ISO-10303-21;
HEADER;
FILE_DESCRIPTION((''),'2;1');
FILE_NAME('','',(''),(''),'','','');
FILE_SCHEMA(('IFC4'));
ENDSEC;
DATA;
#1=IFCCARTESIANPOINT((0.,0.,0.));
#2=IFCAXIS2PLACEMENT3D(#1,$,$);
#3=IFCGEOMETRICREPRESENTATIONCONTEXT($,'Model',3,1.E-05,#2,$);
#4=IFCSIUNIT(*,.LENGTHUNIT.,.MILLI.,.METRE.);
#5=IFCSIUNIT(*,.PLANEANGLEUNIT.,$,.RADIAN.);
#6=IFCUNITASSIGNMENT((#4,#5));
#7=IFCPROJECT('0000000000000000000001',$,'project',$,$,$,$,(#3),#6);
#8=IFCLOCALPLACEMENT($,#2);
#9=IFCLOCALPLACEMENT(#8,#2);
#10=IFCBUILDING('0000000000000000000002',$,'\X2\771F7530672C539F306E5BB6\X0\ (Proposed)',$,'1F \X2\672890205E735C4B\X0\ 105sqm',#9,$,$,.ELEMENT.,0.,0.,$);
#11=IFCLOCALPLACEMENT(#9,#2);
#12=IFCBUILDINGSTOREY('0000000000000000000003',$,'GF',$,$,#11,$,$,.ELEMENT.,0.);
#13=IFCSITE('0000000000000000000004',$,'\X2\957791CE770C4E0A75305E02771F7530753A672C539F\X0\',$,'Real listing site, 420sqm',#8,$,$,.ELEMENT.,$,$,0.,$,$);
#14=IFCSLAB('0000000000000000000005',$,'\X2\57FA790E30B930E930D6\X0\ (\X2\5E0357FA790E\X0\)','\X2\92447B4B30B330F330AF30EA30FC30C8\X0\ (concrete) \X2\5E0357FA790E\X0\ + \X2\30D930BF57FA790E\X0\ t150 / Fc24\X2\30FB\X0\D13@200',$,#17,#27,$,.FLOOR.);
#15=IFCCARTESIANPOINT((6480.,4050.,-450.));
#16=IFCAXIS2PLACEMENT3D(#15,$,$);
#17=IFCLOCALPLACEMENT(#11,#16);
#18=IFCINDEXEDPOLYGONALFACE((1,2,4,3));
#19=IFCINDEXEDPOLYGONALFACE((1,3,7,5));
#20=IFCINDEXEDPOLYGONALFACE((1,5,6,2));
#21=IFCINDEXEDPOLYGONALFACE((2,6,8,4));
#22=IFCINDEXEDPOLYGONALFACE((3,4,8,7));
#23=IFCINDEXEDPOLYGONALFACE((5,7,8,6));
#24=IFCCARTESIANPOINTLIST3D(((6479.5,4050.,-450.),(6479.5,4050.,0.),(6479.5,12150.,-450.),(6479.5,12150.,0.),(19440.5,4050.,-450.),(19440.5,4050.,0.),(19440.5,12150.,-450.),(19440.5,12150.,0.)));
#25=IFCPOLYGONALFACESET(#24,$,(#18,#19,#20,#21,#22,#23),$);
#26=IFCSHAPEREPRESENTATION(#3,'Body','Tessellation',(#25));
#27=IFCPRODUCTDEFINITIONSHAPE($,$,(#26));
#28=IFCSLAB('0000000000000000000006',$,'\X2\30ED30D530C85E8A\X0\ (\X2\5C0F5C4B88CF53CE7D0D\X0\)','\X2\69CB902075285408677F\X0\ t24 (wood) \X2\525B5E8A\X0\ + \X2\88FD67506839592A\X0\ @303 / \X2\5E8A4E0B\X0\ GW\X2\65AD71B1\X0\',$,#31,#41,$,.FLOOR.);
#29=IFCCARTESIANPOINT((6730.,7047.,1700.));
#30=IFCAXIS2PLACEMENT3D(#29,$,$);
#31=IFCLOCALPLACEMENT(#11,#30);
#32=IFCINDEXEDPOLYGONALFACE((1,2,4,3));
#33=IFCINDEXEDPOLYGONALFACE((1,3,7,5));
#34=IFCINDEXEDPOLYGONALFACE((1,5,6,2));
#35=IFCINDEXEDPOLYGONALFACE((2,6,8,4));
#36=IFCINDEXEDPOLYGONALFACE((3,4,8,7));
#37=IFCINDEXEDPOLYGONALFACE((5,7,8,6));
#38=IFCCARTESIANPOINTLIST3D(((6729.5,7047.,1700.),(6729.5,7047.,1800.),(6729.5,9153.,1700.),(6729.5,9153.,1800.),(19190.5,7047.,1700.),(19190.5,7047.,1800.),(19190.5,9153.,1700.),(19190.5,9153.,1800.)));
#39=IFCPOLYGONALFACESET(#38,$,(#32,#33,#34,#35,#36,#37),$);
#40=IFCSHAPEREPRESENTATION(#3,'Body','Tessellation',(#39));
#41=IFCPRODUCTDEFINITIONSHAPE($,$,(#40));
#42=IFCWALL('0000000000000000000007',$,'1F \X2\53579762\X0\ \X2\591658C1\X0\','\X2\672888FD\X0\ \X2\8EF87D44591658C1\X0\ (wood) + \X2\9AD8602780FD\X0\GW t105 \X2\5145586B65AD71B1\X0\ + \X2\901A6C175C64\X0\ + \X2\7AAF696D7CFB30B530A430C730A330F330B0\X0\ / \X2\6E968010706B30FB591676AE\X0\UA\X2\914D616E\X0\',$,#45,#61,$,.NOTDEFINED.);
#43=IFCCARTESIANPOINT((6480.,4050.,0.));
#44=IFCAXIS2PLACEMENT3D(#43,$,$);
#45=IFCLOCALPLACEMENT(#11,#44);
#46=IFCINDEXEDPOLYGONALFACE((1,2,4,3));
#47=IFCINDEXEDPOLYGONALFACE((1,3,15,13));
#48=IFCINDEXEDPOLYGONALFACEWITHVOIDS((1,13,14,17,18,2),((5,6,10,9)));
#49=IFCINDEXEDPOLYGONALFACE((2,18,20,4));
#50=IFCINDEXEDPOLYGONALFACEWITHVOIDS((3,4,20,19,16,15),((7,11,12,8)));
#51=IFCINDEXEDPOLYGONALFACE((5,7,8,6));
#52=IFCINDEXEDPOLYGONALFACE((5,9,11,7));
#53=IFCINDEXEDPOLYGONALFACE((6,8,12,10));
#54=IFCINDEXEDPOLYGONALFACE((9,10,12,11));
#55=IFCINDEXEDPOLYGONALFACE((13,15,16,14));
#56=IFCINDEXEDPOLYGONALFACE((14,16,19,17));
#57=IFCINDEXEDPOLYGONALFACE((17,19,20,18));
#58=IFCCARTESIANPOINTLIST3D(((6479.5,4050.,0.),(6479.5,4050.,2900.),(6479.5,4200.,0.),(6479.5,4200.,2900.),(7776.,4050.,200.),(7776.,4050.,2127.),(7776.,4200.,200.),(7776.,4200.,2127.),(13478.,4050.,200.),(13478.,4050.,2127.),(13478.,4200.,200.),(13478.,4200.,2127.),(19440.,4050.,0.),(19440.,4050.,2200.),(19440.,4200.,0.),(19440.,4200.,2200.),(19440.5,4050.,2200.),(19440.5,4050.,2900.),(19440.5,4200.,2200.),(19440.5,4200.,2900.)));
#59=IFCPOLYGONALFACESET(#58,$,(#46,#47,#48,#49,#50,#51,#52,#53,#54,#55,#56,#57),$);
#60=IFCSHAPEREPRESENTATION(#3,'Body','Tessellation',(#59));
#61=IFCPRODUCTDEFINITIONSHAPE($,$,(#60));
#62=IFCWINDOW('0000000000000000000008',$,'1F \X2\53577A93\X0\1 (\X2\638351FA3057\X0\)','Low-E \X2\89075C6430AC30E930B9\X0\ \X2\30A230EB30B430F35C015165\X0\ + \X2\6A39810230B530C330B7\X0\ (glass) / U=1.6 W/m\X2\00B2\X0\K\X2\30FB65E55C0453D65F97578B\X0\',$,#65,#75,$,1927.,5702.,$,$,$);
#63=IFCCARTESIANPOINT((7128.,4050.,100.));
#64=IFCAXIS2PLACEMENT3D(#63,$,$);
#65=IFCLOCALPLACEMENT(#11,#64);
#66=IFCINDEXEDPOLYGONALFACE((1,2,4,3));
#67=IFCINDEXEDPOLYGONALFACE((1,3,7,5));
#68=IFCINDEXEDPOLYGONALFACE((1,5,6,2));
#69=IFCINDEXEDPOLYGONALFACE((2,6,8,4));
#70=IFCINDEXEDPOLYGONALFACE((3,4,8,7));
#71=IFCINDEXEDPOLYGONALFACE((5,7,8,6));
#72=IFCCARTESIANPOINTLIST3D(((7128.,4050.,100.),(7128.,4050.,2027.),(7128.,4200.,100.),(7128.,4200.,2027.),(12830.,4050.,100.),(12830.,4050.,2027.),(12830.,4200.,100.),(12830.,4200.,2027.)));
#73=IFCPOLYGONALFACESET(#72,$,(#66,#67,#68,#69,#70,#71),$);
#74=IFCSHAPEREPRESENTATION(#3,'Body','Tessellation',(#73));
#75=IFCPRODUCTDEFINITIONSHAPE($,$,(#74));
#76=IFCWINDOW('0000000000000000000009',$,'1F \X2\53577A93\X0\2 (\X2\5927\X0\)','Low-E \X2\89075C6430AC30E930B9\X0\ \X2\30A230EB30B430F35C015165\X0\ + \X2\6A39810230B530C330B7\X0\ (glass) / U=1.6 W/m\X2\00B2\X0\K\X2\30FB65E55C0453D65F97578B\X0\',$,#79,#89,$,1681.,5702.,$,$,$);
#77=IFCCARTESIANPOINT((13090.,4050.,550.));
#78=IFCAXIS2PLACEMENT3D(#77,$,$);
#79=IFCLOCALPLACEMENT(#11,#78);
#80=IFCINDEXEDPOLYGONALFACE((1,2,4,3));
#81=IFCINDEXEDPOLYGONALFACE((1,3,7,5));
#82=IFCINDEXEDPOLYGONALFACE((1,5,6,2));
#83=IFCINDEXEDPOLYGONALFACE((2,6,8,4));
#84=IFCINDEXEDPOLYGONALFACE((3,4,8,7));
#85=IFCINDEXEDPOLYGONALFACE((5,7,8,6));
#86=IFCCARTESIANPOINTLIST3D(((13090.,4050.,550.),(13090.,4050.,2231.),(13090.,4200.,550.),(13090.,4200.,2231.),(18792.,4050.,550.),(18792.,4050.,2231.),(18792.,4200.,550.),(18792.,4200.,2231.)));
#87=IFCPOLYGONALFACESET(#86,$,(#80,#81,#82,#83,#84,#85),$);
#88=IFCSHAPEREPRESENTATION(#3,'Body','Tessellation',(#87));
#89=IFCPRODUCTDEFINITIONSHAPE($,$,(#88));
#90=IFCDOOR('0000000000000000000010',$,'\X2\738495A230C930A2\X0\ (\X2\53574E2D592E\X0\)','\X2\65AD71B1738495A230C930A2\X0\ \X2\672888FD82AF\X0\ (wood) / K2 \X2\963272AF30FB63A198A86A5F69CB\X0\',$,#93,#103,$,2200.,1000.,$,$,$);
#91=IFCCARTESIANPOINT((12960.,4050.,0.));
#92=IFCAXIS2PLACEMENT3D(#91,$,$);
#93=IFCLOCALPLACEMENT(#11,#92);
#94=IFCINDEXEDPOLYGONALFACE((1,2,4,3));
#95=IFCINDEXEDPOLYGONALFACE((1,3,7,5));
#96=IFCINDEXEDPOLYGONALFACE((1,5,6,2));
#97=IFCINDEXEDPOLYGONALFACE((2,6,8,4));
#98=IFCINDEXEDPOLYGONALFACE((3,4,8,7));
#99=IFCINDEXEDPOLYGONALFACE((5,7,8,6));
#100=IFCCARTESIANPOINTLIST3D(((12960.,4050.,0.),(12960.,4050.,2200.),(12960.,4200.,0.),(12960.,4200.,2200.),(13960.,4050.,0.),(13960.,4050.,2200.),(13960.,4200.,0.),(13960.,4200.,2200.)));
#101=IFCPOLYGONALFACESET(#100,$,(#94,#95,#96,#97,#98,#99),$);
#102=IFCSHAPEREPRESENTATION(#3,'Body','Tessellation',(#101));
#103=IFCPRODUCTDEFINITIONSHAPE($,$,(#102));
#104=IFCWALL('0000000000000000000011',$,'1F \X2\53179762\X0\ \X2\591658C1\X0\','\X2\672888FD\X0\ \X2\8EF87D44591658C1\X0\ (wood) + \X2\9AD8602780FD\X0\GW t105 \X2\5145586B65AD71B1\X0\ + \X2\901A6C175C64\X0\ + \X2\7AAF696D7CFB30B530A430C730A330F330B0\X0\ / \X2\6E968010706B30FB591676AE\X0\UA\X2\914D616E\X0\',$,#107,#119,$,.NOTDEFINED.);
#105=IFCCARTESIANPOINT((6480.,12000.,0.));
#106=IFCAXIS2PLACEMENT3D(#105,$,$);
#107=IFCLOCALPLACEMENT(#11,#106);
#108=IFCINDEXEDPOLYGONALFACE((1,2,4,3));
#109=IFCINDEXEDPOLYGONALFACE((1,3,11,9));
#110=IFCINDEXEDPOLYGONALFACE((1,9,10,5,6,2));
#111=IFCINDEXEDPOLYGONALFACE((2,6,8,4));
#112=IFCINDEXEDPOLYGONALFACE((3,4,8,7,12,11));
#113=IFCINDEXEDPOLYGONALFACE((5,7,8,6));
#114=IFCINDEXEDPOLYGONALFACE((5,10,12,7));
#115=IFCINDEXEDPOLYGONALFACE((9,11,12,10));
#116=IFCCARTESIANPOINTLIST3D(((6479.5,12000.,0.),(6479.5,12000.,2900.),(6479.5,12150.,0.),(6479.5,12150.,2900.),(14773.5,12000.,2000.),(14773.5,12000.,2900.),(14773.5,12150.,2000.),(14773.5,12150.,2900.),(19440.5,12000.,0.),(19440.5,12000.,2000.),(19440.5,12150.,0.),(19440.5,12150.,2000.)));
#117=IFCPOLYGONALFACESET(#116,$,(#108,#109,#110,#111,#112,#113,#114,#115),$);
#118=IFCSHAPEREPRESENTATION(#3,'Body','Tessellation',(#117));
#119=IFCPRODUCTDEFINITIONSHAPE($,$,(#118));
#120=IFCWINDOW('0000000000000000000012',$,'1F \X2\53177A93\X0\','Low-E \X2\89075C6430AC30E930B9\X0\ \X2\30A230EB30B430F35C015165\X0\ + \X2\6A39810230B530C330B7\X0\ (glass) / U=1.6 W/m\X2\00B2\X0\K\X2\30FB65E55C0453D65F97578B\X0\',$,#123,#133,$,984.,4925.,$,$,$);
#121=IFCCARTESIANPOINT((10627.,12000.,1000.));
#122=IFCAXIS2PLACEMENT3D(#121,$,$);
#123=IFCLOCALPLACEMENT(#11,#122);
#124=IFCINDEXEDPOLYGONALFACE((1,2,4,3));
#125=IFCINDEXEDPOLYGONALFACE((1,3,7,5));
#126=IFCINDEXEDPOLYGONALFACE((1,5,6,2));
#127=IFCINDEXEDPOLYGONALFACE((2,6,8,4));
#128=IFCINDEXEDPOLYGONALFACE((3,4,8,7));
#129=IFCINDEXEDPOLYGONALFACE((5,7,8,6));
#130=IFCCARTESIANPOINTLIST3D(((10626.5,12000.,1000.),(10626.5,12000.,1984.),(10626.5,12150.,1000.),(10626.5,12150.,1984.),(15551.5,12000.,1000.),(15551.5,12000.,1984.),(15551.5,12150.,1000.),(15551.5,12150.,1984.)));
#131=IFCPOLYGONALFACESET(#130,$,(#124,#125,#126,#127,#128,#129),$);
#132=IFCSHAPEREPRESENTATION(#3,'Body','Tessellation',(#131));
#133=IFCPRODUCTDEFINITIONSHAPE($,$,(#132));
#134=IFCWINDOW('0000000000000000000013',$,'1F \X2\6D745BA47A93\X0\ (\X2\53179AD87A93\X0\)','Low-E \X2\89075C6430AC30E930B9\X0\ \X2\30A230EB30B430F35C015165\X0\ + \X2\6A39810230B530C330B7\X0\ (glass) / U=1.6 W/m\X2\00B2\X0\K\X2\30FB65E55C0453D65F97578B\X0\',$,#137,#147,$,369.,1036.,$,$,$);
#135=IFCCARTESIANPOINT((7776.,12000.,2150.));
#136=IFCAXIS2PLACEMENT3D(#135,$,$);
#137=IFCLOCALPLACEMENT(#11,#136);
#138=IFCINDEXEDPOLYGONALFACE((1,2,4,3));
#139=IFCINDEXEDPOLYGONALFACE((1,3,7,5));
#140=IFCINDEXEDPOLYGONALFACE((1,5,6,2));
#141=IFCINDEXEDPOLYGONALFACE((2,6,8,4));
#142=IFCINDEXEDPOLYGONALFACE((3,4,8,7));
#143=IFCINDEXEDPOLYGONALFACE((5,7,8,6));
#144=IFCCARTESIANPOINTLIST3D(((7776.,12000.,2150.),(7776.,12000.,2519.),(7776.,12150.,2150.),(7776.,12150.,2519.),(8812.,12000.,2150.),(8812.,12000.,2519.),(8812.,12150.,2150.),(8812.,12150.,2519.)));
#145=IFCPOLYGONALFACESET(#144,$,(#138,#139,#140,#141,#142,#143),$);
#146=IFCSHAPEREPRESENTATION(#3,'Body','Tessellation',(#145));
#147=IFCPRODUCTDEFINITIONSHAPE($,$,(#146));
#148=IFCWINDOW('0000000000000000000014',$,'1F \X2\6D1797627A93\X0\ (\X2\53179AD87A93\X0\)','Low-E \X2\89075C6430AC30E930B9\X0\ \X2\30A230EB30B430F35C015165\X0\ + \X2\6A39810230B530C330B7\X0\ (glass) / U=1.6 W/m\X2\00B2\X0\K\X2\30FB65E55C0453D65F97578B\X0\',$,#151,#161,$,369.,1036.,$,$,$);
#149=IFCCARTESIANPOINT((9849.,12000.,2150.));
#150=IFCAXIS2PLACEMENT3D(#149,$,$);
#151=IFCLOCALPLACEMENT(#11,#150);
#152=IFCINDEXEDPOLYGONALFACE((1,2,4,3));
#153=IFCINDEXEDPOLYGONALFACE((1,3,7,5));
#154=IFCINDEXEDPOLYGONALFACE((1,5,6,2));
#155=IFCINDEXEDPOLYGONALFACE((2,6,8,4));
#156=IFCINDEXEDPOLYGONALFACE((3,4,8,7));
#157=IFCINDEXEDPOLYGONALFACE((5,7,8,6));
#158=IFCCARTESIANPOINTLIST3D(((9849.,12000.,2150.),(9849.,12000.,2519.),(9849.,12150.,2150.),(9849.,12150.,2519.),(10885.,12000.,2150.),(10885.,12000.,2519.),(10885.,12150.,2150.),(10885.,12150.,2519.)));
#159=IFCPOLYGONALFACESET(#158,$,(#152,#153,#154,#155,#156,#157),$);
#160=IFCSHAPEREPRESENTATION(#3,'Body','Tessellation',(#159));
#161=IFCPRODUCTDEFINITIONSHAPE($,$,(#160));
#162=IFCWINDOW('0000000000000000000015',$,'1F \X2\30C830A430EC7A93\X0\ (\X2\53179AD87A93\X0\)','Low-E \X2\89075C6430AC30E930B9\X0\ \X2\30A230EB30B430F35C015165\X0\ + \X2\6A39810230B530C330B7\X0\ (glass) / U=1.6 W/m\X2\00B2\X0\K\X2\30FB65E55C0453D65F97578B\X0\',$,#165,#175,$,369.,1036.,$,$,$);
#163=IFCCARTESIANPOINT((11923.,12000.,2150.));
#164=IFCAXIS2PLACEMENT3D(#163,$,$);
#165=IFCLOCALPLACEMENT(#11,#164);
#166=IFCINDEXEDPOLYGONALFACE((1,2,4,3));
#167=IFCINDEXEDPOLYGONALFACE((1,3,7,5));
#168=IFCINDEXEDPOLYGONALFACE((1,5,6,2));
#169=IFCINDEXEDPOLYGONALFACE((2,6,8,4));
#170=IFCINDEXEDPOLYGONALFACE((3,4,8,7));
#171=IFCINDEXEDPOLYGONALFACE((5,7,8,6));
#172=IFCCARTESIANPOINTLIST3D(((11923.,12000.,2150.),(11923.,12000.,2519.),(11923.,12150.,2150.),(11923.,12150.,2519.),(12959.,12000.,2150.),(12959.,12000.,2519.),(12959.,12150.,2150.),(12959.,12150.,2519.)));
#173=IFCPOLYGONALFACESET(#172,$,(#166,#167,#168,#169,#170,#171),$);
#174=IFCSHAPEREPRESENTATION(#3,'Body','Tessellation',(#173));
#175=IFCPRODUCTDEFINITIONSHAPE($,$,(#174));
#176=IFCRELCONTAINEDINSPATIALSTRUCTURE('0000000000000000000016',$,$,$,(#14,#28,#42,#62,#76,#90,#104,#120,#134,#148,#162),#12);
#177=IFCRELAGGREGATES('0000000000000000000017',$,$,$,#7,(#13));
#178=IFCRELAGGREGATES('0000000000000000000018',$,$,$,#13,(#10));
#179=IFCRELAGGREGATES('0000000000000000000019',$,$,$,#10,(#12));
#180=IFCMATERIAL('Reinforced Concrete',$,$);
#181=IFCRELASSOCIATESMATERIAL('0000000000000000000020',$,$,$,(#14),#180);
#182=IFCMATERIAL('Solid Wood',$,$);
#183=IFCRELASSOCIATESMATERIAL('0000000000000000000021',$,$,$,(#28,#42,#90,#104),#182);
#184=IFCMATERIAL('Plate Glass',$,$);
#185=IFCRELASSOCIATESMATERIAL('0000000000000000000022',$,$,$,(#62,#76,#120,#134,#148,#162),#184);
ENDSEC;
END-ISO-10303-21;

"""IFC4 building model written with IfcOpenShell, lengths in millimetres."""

from ifc_helpers import new_model, si_unit, frame, frame_2d, origin, place, context, project, spatial, rectangle, extrude, material, element, fill, save


model = new_model("IFC4")

# Units and contexts
model_context = context("Model", 3, precision=1e-05, world=origin())
ifc_project = project(units=[si_unit("LENGTHUNIT", "METRE", prefix="MILLI"), si_unit("PLANEANGLEUNIT", "RADIAN")], contexts=[model_context])

# Site, building, storey
site_placement = place(None, origin())
site = spatial("IfcSite", under=ifc_project, at=site_placement, Name="長野県上田市真田町本原", ObjectType="Real listing site, 420sqm", CompositionType="ELEMENT", RefElevation=0.0)
building_placement = place(site_placement, origin())
building = spatial("IfcBuilding", under=site, at=building_placement, Name="真田本原の家 (Proposed)", ObjectType="1F 木造平屋 105sqm", CompositionType="ELEMENT", ElevationOfRefHeight=0.0, ElevationOfTerrain=0.0)
storey_placement = place(building_placement, origin())
storey = spatial("IfcBuildingStorey", under=building, at=storey_placement, Name="GF", CompositionType="ELEMENT", Elevation=0.0)

# Slabs
ifc_material_1 = material(Name="Reinforced Concrete")
slab_1_placement = place(storey_placement, frame((6480.0, 4050.0, -450.0)))
element("IfcSlab", 1, at=slab_1_placement, inside=storey, material=ifc_material_1, Name="基礎スラブ (布基礎)", Description="鉄筋コンクリート (concrete) 布基礎 + ベタ基礎 t150 / Fc24・D13@200", PredefinedType="FLOOR", context=model_context, shape_type="SweptSolid", body=[
    extrude(rectangle(XDim=12961.0, YDim=8100.0, at=frame_2d((6480.0, 4050.0))), frame((6480.0, 4050.0, -450.0)), (0.0, 0.0, 1.0), 450.0),
])
ifc_material_2 = material(Name="Solid Wood")
slab_2_placement = place(storey_placement, frame((6730.0, 7047.0, 1700.0)))
element("IfcSlab", 2, at=slab_2_placement, inside=storey, material=ifc_material_2, Name="ロフト床 (小屋裏収納)", Description="構造用合板 t24 (wood) 剛床 + 製材根太 @303 / 床下 GW断熱", PredefinedType="FLOOR", context=model_context, shape_type="SweptSolid", body=[
    extrude(rectangle(XDim=12461.0, YDim=2106.0, at=frame_2d((6230.0, 1053.0))), frame((6730.0, 7047.0, 1700.0)), (0.0, 0.0, 1.0), 100.0),
])

# Wall, openings, windows, door
wall_1_placement = place(storey_placement, frame((6480.0, 4050.0, 0.0)))
wall_1 = element("IfcWall", 3, at=wall_1_placement, inside=storey, material=ifc_material_2, Name="1F 南面 外壁", Description="木製 軸組外壁 (wood) + 高性能GW t105 充填断熱 + 通気層 + 窯業系サイディング / 準耐火・外皮UA配慮", PredefinedType="NOTDEFINED", context=model_context, shape_type="SweptSolid", body=[
    extrude(rectangle(XDim=12961.0, YDim=150.0, at=frame_2d((6480.0, 75.0))), frame((6480.0, 4050.0, 0.0)), (0.0, 0.0, 1.0), 2900.0),
])
opening_1_placement = place(storey_placement, frame((7128.0, 4050.0, 100.0)))
opening_1 = element("IfcOpeningElement", 4, at=opening_1_placement, cuts=wall_1, PredefinedType="NOTDEFINED", context=model_context, shape_type="SweptSolid", body=[
    extrude(rectangle(XDim=5702.0, YDim=150.0, at=frame_2d((2851.0, 75.0))), frame((7128.0, 4050.0, 100.0)), (0.0, 0.0, 1.0), 1927.0),
])
opening_2_placement = place(storey_placement, frame((13090.0, 4050.0, 550.0)))
opening_2 = element("IfcOpeningElement", 5, at=opening_2_placement, cuts=wall_1, PredefinedType="NOTDEFINED", context=model_context, shape_type="SweptSolid", body=[
    extrude(rectangle(XDim=5702.0, YDim=150.0, at=frame_2d((2851.0, 75.0))), frame((13090.0, 4050.0, 550.0)), (0.0, 0.0, 1.0), 1681.0),
])
opening_3_placement = place(storey_placement, frame((12960.0, 4050.0, 0.0)))
opening_3 = element("IfcOpeningElement", 6, at=opening_3_placement, cuts=wall_1, PredefinedType="NOTDEFINED", context=model_context, shape_type="SweptSolid", body=[
    extrude(rectangle(XDim=1000.0, YDim=150.0, at=frame_2d((500.0, 75.0))), frame((12960.0, 4050.0, 0.0)), (0.0, 0.0, 1.0), 2200.0),
])
ifc_material_3 = material(Name="Plate Glass")
window_1_placement = place(storey_placement, frame((7128.0, 4050.0, 100.0)))
window_1 = element("IfcWindow", 7, at=window_1_placement, inside=storey, material=ifc_material_3, Name="1F 南窓1 (掃出し)", Description="Low-E 複層ガラス アルゴン封入 + 樹脂サッシ (glass) / U=1.6 W/m²K・日射取得型", OverallHeight=1927.0, OverallWidth=5702.0, context=model_context, shape_type="SweptSolid", body=[
    extrude(rectangle(XDim=5702.0, YDim=150.0, at=frame_2d((2851.0, 75.0))), frame((7128.0, 4050.0, 100.0)), (0.0, 0.0, 1.0), 1927.0),
])
fill(opening_1, window_1)
window_2_placement = place(storey_placement, frame((13090.0, 4050.0, 550.0)))
window_2 = element("IfcWindow", 8, at=window_2_placement, inside=storey, material=ifc_material_3, Name="1F 南窓2 (大)", Description="Low-E 複層ガラス アルゴン封入 + 樹脂サッシ (glass) / U=1.6 W/m²K・日射取得型", OverallHeight=1681.0, OverallWidth=5702.0, context=model_context, shape_type="SweptSolid", body=[
    extrude(rectangle(XDim=5702.0, YDim=150.0, at=frame_2d((2851.0, 75.0))), frame((13090.0, 4050.0, 550.0)), (0.0, 0.0, 1.0), 1681.0),
])
fill(opening_2, window_2)
door_1_placement = place(storey_placement, frame((12960.0, 4050.0, 0.0)))
door_1 = element("IfcDoor", 9, at=door_1_placement, inside=storey, material=ifc_material_2, Name="玄関ドア (南中央)", Description="断熱玄関ドア 木製芯 (wood) / K2 防犯・採風機構", OverallHeight=2200.0, OverallWidth=1000.0, context=model_context, shape_type="SweptSolid", body=[
    extrude(rectangle(XDim=1000.0, YDim=150.0, at=frame_2d((500.0, 75.0))), frame((12960.0, 4050.0, 0.0)), (0.0, 0.0, 1.0), 2200.0),
])
fill(opening_3, door_1)

# Wall, openings, windows
wall_2_placement = place(storey_placement, frame((6480.0, 12000.0, 0.0)))
wall_2 = element("IfcWall", 10, at=wall_2_placement, inside=storey, material=ifc_material_2, Name="1F 北面 外壁", Description="木製 軸組外壁 (wood) + 高性能GW t105 充填断熱 + 通気層 + 窯業系サイディング / 準耐火・外皮UA配慮", PredefinedType="NOTDEFINED", context=model_context, shape_type="SweptSolid", body=[
    extrude(rectangle(XDim=12961.0, YDim=150.0, at=frame_2d((6480.0, 75.0))), frame((6480.0, 12000.0, 0.0)), (0.0, 0.0, 1.0), 2900.0),
])
opening_4_placement = place(storey_placement, frame((10627.0, 12000.0, 1000.0)))
opening_4 = element("IfcOpeningElement", 11, at=opening_4_placement, cuts=wall_2, PredefinedType="NOTDEFINED", context=model_context, shape_type="SweptSolid", body=[
    extrude(rectangle(XDim=4925.0, YDim=150.0, at=frame_2d((2462.0, 75.0))), frame((10627.0, 12000.0, 1000.0)), (0.0, 0.0, 1.0), 984.0),
])
opening_5_placement = place(storey_placement, frame((7776.0, 12000.0, 2150.0)))
opening_5 = element("IfcOpeningElement", 12, at=opening_5_placement, cuts=wall_2, PredefinedType="NOTDEFINED", context=model_context, shape_type="SweptSolid", body=[
    extrude(rectangle(XDim=1036.0, YDim=150.0, at=frame_2d((518.0, 75.0))), frame((7776.0, 12000.0, 2150.0)), (0.0, 0.0, 1.0), 369.0),
])
opening_6_placement = place(storey_placement, frame((9849.0, 12000.0, 2150.0)))
opening_6 = element("IfcOpeningElement", 13, at=opening_6_placement, cuts=wall_2, PredefinedType="NOTDEFINED", context=model_context, shape_type="SweptSolid", body=[
    extrude(rectangle(XDim=1036.0, YDim=150.0, at=frame_2d((518.0, 75.0))), frame((9849.0, 12000.0, 2150.0)), (0.0, 0.0, 1.0), 369.0),
])
opening_7_placement = place(storey_placement, frame((11923.0, 12000.0, 2150.0)))
opening_7 = element("IfcOpeningElement", 14, at=opening_7_placement, cuts=wall_2, PredefinedType="NOTDEFINED", context=model_context, shape_type="SweptSolid", body=[
    extrude(rectangle(XDim=1036.0, YDim=150.0, at=frame_2d((518.0, 75.0))), frame((11923.0, 12000.0, 2150.0)), (0.0, 0.0, 1.0), 369.0),
])
window_3_placement = place(storey_placement, frame((10627.0, 12000.0, 1000.0)))
window_3 = element("IfcWindow", 15, at=window_3_placement, inside=storey, material=ifc_material_3, Name="1F 北窓", Description="Low-E 複層ガラス アルゴン封入 + 樹脂サッシ (glass) / U=1.6 W/m²K・日射取得型", OverallHeight=984.0, OverallWidth=4925.0, context=model_context, shape_type="SweptSolid", body=[
    extrude(rectangle(XDim=4925.0, YDim=150.0, at=frame_2d((2462.0, 75.0))), frame((10627.0, 12000.0, 1000.0)), (0.0, 0.0, 1.0), 984.0),
])
fill(opening_4, window_3)
window_4_placement = place(storey_placement, frame((7776.0, 12000.0, 2150.0)))
window_4 = element("IfcWindow", 16, at=window_4_placement, inside=storey, material=ifc_material_3, Name="1F 浴室窓 (北高窓)", Description="Low-E 複層ガラス アルゴン封入 + 樹脂サッシ (glass) / U=1.6 W/m²K・日射取得型", OverallHeight=369.0, OverallWidth=1036.0, context=model_context, shape_type="SweptSolid", body=[
    extrude(rectangle(XDim=1036.0, YDim=150.0, at=frame_2d((518.0, 75.0))), frame((7776.0, 12000.0, 2150.0)), (0.0, 0.0, 1.0), 369.0),
])
fill(opening_5, window_4)
window_5_placement = place(storey_placement, frame((9849.0, 12000.0, 2150.0)))
window_5 = element("IfcWindow", 17, at=window_5_placement, inside=storey, material=ifc_material_3, Name="1F 洗面窓 (北高窓)", Description="Low-E 複層ガラス アルゴン封入 + 樹脂サッシ (glass) / U=1.6 W/m²K・日射取得型", OverallHeight=369.0, OverallWidth=1036.0, context=model_context, shape_type="SweptSolid", body=[
    extrude(rectangle(XDim=1036.0, YDim=150.0, at=frame_2d((518.0, 75.0))), frame((9849.0, 12000.0, 2150.0)), (0.0, 0.0, 1.0), 369.0),
])
fill(opening_6, window_5)
window_6_placement = place(storey_placement, frame((11923.0, 12000.0, 2150.0)))
window_6 = element("IfcWindow", 18, at=window_6_placement, inside=storey, material=ifc_material_3, Name="1F トイレ窓 (北高窓)", Description="Low-E 複層ガラス アルゴン封入 + 樹脂サッシ (glass) / U=1.6 W/m²K・日射取得型", OverallHeight=369.0, OverallWidth=1036.0, context=model_context, shape_type="SweptSolid", body=[
    extrude(rectangle(XDim=1036.0, YDim=150.0, at=frame_2d((518.0, 75.0))), frame((11923.0, 12000.0, 2150.0)), (0.0, 0.0, 1.0), 369.0),
])
fill(opening_7, window_6)

save(model, "model.ifc")
